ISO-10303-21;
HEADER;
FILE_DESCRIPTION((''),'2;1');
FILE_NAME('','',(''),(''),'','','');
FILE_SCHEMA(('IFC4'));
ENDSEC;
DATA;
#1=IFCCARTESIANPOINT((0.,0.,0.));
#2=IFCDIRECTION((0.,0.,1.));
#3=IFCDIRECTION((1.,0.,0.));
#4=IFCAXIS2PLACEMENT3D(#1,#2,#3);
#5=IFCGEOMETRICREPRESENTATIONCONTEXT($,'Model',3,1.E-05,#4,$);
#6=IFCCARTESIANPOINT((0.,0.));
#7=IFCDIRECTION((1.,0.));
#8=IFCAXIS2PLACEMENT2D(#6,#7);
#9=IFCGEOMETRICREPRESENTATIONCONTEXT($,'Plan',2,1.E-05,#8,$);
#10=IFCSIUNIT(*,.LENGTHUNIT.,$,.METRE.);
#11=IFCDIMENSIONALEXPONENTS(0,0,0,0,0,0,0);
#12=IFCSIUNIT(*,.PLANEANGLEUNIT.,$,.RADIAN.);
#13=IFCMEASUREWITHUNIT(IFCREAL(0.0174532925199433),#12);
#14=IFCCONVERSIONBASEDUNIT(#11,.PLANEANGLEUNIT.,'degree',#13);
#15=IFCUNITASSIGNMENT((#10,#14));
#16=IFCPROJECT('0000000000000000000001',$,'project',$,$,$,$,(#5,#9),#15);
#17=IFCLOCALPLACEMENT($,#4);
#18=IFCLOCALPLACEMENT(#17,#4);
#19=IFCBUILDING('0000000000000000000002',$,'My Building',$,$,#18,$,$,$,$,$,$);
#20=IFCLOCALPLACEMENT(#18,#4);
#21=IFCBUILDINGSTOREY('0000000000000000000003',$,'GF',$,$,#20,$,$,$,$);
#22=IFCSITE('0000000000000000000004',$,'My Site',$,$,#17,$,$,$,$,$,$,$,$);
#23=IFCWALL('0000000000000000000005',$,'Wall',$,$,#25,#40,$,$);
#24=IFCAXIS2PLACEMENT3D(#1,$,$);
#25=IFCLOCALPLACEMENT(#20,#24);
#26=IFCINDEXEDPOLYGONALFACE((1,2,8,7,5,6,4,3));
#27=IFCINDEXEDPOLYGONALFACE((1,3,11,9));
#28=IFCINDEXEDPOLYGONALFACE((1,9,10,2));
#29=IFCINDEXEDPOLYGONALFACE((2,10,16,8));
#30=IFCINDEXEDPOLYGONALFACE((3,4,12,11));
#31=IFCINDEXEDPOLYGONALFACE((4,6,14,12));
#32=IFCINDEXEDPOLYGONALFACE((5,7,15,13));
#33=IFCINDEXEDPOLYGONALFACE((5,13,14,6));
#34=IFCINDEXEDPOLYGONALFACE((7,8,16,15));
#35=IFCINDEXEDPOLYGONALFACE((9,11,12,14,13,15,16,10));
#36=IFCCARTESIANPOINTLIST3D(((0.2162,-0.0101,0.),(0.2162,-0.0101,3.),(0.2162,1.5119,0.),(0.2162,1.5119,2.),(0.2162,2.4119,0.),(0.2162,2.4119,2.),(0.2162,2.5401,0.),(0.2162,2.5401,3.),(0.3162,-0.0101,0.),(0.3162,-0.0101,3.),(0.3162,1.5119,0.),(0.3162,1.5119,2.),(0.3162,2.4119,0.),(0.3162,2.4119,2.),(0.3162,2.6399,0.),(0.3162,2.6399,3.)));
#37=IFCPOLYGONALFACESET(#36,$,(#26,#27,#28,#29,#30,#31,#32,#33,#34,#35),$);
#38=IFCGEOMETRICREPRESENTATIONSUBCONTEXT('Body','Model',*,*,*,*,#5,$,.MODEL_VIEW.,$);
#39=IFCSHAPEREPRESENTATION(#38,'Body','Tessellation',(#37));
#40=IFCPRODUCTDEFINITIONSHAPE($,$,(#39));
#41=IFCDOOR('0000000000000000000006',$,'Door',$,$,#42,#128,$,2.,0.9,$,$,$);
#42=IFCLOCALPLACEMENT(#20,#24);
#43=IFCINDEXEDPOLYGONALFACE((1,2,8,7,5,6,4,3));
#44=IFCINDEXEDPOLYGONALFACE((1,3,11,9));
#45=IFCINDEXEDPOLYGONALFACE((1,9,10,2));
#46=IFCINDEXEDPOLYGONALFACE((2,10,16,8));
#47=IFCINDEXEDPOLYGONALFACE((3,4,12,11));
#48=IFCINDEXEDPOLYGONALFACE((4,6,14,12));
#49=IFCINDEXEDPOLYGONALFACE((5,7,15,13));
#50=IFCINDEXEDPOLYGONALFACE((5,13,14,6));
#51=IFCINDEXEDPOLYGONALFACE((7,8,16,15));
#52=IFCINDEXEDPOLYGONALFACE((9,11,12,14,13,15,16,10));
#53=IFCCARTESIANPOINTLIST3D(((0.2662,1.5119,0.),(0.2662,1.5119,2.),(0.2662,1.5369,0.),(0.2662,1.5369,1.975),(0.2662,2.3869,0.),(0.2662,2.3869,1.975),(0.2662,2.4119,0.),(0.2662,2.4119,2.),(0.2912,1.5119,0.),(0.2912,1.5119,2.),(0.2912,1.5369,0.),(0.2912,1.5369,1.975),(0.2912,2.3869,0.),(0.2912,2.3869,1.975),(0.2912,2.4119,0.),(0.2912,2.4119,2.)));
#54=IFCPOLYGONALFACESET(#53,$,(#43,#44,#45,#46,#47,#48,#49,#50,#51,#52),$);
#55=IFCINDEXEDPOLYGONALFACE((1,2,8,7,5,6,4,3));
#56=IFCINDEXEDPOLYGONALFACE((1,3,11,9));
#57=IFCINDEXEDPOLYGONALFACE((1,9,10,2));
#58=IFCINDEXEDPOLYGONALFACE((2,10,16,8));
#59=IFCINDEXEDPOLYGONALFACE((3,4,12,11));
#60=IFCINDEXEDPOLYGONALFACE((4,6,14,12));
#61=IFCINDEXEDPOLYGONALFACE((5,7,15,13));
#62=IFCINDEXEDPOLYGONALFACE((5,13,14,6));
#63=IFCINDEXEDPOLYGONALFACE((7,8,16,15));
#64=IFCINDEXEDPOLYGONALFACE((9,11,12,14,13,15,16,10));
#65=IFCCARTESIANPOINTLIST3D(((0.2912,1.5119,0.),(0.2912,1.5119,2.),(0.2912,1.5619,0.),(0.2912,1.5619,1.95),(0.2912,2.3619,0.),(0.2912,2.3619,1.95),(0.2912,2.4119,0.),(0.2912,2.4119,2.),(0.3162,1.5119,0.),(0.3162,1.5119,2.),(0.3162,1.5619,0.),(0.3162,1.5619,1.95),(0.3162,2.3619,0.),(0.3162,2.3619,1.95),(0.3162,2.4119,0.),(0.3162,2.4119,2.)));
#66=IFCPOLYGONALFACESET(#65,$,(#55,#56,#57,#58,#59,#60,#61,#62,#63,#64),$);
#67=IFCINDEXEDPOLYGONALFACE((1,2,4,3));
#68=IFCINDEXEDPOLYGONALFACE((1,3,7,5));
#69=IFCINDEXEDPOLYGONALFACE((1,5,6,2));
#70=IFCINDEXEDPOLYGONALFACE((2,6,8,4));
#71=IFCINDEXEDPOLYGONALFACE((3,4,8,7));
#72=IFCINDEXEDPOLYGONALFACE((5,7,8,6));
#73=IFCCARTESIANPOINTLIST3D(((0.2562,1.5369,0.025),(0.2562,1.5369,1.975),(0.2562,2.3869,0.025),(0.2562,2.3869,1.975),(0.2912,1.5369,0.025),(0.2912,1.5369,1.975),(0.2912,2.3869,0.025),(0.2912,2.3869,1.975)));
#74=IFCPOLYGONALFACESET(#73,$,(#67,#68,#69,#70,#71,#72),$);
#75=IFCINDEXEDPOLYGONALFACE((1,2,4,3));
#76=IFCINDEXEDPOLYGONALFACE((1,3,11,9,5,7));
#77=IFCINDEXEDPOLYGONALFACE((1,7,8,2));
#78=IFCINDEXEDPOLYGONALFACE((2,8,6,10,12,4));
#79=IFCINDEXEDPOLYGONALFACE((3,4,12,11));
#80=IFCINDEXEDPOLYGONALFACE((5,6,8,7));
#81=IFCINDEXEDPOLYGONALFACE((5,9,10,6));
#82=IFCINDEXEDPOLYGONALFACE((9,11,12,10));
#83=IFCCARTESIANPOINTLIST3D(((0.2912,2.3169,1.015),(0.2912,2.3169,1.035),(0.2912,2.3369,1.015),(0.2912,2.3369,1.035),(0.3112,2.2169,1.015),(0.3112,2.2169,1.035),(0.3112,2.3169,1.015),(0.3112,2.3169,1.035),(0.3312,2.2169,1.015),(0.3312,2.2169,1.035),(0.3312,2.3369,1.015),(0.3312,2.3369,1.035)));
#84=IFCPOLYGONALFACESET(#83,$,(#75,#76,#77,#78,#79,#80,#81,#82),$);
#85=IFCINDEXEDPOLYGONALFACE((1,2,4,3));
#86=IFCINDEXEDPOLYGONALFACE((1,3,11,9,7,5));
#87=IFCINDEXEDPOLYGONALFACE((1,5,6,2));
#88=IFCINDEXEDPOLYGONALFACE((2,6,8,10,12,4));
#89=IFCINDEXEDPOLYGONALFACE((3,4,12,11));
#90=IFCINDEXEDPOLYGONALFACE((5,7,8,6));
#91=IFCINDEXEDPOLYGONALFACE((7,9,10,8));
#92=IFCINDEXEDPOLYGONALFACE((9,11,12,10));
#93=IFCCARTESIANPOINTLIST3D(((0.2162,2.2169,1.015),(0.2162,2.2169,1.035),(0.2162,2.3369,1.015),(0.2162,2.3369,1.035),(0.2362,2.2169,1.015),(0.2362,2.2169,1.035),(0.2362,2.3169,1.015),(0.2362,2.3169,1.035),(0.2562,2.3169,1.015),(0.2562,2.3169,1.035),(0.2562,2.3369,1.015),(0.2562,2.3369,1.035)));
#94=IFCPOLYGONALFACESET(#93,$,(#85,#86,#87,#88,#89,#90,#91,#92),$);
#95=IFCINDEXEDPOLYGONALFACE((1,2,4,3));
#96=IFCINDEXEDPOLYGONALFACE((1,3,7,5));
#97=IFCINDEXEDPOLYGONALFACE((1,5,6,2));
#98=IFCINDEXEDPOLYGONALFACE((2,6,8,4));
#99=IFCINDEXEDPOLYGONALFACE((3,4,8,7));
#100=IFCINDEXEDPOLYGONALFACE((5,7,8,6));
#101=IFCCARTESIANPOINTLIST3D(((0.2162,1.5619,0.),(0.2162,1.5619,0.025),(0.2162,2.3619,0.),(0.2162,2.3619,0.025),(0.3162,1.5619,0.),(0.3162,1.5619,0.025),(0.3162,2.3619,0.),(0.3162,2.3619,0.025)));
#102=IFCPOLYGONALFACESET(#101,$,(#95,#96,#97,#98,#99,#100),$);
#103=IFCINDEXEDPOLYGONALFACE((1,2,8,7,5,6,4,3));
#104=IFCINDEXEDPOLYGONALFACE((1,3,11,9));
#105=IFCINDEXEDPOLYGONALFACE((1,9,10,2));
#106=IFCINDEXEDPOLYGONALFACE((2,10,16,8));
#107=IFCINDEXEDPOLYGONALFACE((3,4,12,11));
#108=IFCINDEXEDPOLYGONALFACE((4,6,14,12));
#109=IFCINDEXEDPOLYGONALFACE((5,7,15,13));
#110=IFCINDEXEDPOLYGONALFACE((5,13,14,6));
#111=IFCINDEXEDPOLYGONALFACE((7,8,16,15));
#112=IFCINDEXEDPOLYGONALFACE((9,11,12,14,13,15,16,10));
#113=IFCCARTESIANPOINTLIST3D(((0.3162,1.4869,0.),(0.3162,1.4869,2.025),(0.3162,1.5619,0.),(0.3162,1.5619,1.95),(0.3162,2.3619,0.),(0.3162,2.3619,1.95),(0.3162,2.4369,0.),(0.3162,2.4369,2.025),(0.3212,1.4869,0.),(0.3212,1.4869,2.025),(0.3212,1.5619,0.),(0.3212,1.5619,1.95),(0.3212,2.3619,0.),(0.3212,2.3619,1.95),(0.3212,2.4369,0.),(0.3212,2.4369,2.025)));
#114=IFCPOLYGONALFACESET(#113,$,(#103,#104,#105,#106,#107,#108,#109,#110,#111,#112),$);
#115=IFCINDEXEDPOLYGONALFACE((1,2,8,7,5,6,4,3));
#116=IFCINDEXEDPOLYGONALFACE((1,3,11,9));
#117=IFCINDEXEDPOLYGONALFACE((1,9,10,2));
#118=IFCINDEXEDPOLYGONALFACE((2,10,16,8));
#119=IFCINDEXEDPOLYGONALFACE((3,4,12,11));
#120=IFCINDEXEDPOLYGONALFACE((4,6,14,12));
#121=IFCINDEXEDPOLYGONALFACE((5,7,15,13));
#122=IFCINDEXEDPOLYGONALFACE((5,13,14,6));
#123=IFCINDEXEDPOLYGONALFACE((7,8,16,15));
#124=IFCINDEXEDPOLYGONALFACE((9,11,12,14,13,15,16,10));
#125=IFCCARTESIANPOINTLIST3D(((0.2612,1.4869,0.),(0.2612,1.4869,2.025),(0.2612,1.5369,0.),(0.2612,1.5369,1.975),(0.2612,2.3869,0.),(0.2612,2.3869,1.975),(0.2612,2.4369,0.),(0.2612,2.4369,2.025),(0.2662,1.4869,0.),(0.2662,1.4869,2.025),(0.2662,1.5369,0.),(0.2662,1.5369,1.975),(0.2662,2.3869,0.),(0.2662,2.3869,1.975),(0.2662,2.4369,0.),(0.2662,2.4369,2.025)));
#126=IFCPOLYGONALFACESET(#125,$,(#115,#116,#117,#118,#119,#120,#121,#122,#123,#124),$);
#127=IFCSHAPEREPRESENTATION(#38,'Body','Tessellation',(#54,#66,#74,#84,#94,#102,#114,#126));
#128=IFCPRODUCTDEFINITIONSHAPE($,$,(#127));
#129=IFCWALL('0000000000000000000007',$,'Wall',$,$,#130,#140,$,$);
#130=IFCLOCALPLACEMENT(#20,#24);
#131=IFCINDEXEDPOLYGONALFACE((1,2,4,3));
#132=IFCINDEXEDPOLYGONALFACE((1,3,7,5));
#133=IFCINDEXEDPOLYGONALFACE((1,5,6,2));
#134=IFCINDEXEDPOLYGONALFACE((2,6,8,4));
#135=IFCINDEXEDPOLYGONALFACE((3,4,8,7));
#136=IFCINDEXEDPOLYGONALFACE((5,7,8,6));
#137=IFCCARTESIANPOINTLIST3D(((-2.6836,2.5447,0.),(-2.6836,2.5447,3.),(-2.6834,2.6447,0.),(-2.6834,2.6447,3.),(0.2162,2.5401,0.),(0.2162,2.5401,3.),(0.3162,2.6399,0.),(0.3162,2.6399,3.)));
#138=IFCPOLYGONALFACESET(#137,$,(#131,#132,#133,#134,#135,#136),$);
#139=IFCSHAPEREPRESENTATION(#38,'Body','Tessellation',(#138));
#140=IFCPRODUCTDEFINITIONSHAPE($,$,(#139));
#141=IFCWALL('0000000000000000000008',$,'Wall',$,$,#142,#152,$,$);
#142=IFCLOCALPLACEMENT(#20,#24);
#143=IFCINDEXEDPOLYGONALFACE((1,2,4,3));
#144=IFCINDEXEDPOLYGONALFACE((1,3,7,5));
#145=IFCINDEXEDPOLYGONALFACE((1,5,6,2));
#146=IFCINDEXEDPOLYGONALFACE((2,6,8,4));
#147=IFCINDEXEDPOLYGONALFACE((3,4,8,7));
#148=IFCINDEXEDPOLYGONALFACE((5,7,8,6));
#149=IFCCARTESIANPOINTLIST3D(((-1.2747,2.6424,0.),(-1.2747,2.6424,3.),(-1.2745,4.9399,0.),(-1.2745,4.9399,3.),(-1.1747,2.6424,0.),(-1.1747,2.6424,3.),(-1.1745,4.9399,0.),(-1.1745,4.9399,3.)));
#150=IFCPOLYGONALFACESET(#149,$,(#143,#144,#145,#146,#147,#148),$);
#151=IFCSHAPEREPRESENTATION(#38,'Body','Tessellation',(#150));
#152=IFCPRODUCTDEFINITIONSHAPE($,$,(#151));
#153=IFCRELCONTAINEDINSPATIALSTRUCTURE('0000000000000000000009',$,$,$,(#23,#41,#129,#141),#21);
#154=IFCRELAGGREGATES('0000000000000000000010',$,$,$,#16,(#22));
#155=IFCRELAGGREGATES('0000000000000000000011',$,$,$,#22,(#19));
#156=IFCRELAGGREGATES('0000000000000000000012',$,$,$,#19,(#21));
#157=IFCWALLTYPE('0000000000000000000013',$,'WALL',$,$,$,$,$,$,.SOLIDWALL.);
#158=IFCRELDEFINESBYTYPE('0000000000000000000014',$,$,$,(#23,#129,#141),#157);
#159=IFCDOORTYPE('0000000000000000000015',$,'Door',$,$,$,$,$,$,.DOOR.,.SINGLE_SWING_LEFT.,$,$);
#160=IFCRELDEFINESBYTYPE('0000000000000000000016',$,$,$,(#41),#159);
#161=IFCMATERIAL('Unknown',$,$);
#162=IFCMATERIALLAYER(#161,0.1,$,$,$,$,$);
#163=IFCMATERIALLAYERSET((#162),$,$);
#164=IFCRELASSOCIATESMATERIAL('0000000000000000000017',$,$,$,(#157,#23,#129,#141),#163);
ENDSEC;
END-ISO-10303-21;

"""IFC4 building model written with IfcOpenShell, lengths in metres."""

from ifc_helpers import new_model, entity, si_unit, converted_unit, frame, origin_with_axes, origin_2d_with_axis, place, context, subcontext, project, spatial, line, indexed_curve, outline, extrude, shape, source, transform, mapped, material, layer, layer_set, layer_usage, type_object, type_shapes, element, fill, save


model = new_model("IFC4")

# Units and contexts
model_context = context("Model", 3, precision=1e-05, world=origin_with_axes())
plan_context = context("Plan", 2, precision=1e-05, world=origin_2d_with_axis())
body_context_1 = subcontext(model_context, "Body", "Model", "MODEL_VIEW")
body_context_2 = subcontext(plan_context, "Body", "Plan", "PLAN_VIEW")
ifc_project = project(units=[si_unit("LENGTHUNIT", "METRE"), converted_unit("PLANEANGLEUNIT", "degree", entity("IfcReal", 0.0174532925199433), si_unit("PLANEANGLEUNIT", "RADIAN"), dimensions=[0, 0, 0, 0, 0, 0, 0])], contexts=[model_context, plan_context])

# Site, building, storey
site_placement = place(None, origin_with_axes())
site = spatial("IfcSite", under=ifc_project, at=site_placement, Name="My Site")
building_placement = place(site_placement, origin_with_axes())
building = spatial("IfcBuilding", under=site, at=building_placement, Name="My Building")
storey_placement = place(building_placement, origin_with_axes())
storey = spatial("IfcBuildingStorey", under=building, at=storey_placement, Name="GF")

# Shared definitions
ifc_material = material(Name="Unknown")

# Shared definitions
ifc_layer_1 = layer(ifc_material, 0.1)
ifc_layer_set_1 = layer_set([ifc_layer_1])
wall_type = type_object("IfcWallType", Name="WALL", PredefinedType="SOLIDWALL", material=ifc_layer_set_1)
shared_shape_1 = source(origin_with_axes(), body_context_1, "Body", "SweptSolid", [
    extrude(outline(indexed_curve([(0.0, 0.0), (0.9, 0.0), (0.9, 2.0), (0.0, 2.0)], segments=[line(1, 2, 3, 4, 1)])), frame((0.0, -0.6, 0.0), z_axis=(0.0, -1.0, 0.0), x_axis=(1.0, 0.0, 0.0)), (0.0, 0.0, -1.0), 1.2),
])
door_type = type_object("IfcDoorType", Name="Door", OperationType="SINGLE_SWING_LEFT", PredefinedType="DOOR")
shared_shape_2 = source(origin_with_axes(), body_context_1, "Body", "SweptSolid", [
    extrude(outline(indexed_curve([(0.0, 0.0), (0.0, 2.0), (0.9, 2.0), (0.9, 0.0), (0.875, 0.0), (0.875, 1.975), (0.025, 1.975), (0.025, 0.0)], segments=[line(1, 2, 3, 4, 5, 6, 7, 8, 1)])), frame((0.0, 0.025, 0.0), z_axis=(0.0, -1.0, 0.0), x_axis=(1.0, 0.0, 0.0)), (0.0, 0.0, -1.0), 0.025),
    extrude(outline(indexed_curve([(0.0, 0.0), (0.0, 2.0), (0.9, 2.0), (0.9, 0.0), (0.85, 0.0), (0.85, 1.95), (0.05, 1.95), (0.05, 0.0)], segments=[line(1, 2, 3, 4, 5, 6, 7, 8, 1)])), frame((0.0, 0.0, 0.0), z_axis=(0.0, -1.0, 0.0), x_axis=(1.0, 0.0, 0.0)), (0.0, 0.0, -1.0), 0.025),
    extrude(outline(indexed_curve([(0.0, 0.0), (0.85, 0.0), (0.85, 0.035), (0.0, 0.035)], segments=[line(1, 2, 3, 4, 1)])), frame((0.025, 0.025, 0.025), z_axis=(0.0, 0.0, 1.0), x_axis=(1.0, 0.0, 0.0)), (0.0, 0.0, 1.0), 1.95),
    extrude(outline(indexed_curve([(0.0, 0.0), (0.0, -0.04), (-0.12, -0.04), (-0.12, -0.02), (-0.02, -0.02), (-0.02, 0.0)], segments=[line(1, 2, 3, 4, 5, 6, 1)])), frame((0.825, 0.025, 1.015), z_axis=(0.0, 0.0, 1.0), x_axis=(1.0, 0.0, 0.0)), (0.0, 0.0, 1.0), 0.02),
    extrude(outline(indexed_curve([(0.0, 0.0), (0.0, 0.04), (-0.12, 0.04), (-0.12, 0.02), (-0.02, 0.02), (-0.02, 0.0)], segments=[line(1, 2, 3, 4, 5, 6, 1)])), frame((0.825, 0.06, 1.015), z_axis=(0.0, 0.0, 1.0), x_axis=(1.0, 0.0, 0.0)), (0.0, 0.0, 1.0), 0.02),
    extrude(outline(indexed_curve([(0.0, 0.0), (0.8, 0.0), (0.8, 0.1), (0.0, 0.1)], segments=[line(1, 2, 3, 4, 1)])), frame((0.05, 0.0, 0.0), z_axis=(0.0, 0.0, 1.0), x_axis=(1.0, 0.0, 0.0)), (0.0, 0.0, 1.0), 0.025),
    extrude(outline(indexed_curve([(0.0, 0.0), (0.0, 2.025), (0.95, 2.025), (0.95, 0.0), (0.875, 0.0), (0.875, 1.95), (0.075, 1.95), (0.075, 0.0)], segments=[line(1, 2, 3, 4, 5, 6, 7, 8, 1)])), frame((-0.025, -0.005, 0.0), z_axis=(0.0, -1.0, 0.0), x_axis=(1.0, 0.0, 0.0)), (0.0, 0.0, -1.0), 0.005),
    extrude(outline(indexed_curve([(0.0, 0.0), (0.0, 2.025), (0.95, 2.025), (0.95, 0.0), (0.9, 0.0), (0.9, 1.975), (0.05, 1.975), (0.05, 0.0)], segments=[line(1, 2, 3, 4, 5, 6, 7, 8, 1)])), frame((-0.025, 0.05, 0.0), z_axis=(0.0, -1.0, 0.0), x_axis=(1.0, 0.0, 0.0)), (0.0, 0.0, -1.0), 0.005),
])
shared_shape_3 = source(origin_with_axes(), body_context_2, "Body", "Curve2D", [
    entity("IfcIndexedPolyCurve", entity("IfcCartesianPointList2D", [[0.0, 0.0], [0.0, 0.05], [0.025, 0.05], [0.025, 0.025], [0.05, 0.025], [0.05, 0.0]]), [entity("IfcLineIndex", [1, 2, 3, 4, 5, 6, 1])]),
    entity("IfcIndexedPolyCurve", entity("IfcCartesianPointList2D", [[0.9, 0.0], [0.9, 0.05], [0.875, 0.05], [0.875, 0.025], [0.85, 0.025], [0.85, 0.0]]), [entity("IfcLineIndex", [1, 2, 3, 4, 5, 6, 1])]),
    entity("IfcTrimmedCurve", entity("IfcEllipse", entity("IfcAxis2Placement2D", entity("IfcCartesianPoint", [0.06, 0.05]), entity("IfcDirection", [1.0, 0.0])), 0.815, 0.85), [entity("IfcCartesianPoint", [0.875, 0.05])], [entity("IfcCartesianPoint", [0.06, 0.9])], True, "CARTESIAN"),
    entity("IfcIndexedPolyCurve", entity("IfcCartesianPointList2D", [[0.025, 0.05], [0.06, 0.05], [0.06, 0.9], [0.025, 0.9]]), [entity("IfcLineIndex", [1, 2, 3, 4, 1])]),
])
type_shapes(door_type, [shared_shape_2, shared_shape_3])

# Wall, opening, door
ifc_layer_usage_1 = layer_usage(ifc_layer_set_1, "AXIS2", "POSITIVE", 0.0)
wall_1_placement = place(storey_placement, frame((0.3162, -0.0101, 0.0), z_axis=(0.0, 0.0, 1.0), x_axis=(0.0, 1.0, 0.0)))
wall_1 = element("IfcWall", 1, at=wall_1_placement, inside=storey, type_object=wall_type, material=ifc_layer_usage_1, Name="Wall", context=body_context_1, shape_type="SweptSolid", body=[
    extrude(outline(indexed_curve([(0.0, 0.0), (0.0, 0.1), (2.5502, 0.1), (2.65, 0.0)], segments=[line(1, 2, 3, 4, 1)])), origin_with_axes(), (0.0, 0.0, 1.0), 3.0),
])
opening_1_placement = place(wall_1_placement, frame((1.522, 0.0, 0.0), z_axis=(0.0, 0.0, 1.0), x_axis=(1.0, 0.0, 0.0)))
opening_1 = element("IfcOpeningElement", 2, at=opening_1_placement, cuts=wall_1, PredefinedType="OPENING", context=body_context_1, shape_type="MappedRepresentation", body=[
    mapped(shared_shape_1, transform((0.0, 0.0, 0.0), x_axis=(1.0, 0.0, 0.0), y_axis=(0.0, 1.0, 0.0), z_axis=(0.0, 0.0, 1.0), scale=1.0)),
])
door_1_placement = place(opening_1_placement, frame((0.0, 0.0, 0.0), z_axis=(0.0, 0.0, 1.0), x_axis=(1.0, 0.0, 0.0)))
door_1 = element("IfcDoor", 3, at=door_1_placement, inside=storey, type_object=door_type, Name="Door", OverallHeight=2.0, OverallWidth=0.9, shapes=[
    shape(body_context_1, "Body", "MappedRepresentation", [mapped(shared_shape_2, transform((0.0, 0.0, 0.0), x_axis=(1.0, 0.0, 0.0), y_axis=(0.0, 1.0, 0.0), z_axis=(0.0, 0.0, 1.0), scale=1.0))]),
    shape(body_context_2, "Body", "MappedRepresentation", [mapped(shared_shape_3, transform((0.0, 0.0, 0.0), x_axis=(1.0, 0.0, 0.0), y_axis=(0.0, 1.0, 0.0), z_axis=(0.0, 0.0, 1.0), scale=1.0))]),
])
fill(opening_1, door_1)

# Walls
ifc_layer_usage_2 = layer_usage(ifc_layer_set_1, "AXIS2", "POSITIVE", 0.0)
wall_2_placement = place(storey_placement, frame((0.3162, 2.6399, 0.0), z_axis=(0.0, 0.0, 1.0), x_axis=(-0.999999, 0.001594, 0.0)))
element("IfcWall", 4, at=wall_2_placement, inside=storey, type_object=wall_type, material=ifc_layer_usage_2, Name="Wall", context=body_context_1, shape_type="SweptSolid", body=[
    extrude(outline(indexed_curve([(0.0, 0.0), (0.0998, 0.1), (2.9996, 0.1), (2.9996, 0.0)], segments=[line(1, 2, 3, 4, 1)])), origin_with_axes(), (0.0, 0.0, 1.0), 3.0),
])
ifc_layer_usage_3 = layer_usage(ifc_layer_set_1, "AXIS2", "POSITIVE", 0.0)
wall_3_placement = place(storey_placement, frame((-1.2745, 4.9399, 0.0), z_axis=(0.0, 0.0, 1.0), x_axis=(-0.000123, -1.0, 0.0)))
element("IfcWall", 5, at=wall_3_placement, inside=storey, type_object=wall_type, material=ifc_layer_usage_3, Name="Wall", context=body_context_1, shape_type="SweptSolid", body=[
    extrude(outline(indexed_curve([(0.0, 0.0), (0.0, 0.1), (2.2975, 0.1), (2.2975, 0.0)], segments=[line(1, 2, 3, 4, 1)])), origin_with_axes(), (0.0, 0.0, 1.0), 3.0),
])

save(model, "model.ifc")
